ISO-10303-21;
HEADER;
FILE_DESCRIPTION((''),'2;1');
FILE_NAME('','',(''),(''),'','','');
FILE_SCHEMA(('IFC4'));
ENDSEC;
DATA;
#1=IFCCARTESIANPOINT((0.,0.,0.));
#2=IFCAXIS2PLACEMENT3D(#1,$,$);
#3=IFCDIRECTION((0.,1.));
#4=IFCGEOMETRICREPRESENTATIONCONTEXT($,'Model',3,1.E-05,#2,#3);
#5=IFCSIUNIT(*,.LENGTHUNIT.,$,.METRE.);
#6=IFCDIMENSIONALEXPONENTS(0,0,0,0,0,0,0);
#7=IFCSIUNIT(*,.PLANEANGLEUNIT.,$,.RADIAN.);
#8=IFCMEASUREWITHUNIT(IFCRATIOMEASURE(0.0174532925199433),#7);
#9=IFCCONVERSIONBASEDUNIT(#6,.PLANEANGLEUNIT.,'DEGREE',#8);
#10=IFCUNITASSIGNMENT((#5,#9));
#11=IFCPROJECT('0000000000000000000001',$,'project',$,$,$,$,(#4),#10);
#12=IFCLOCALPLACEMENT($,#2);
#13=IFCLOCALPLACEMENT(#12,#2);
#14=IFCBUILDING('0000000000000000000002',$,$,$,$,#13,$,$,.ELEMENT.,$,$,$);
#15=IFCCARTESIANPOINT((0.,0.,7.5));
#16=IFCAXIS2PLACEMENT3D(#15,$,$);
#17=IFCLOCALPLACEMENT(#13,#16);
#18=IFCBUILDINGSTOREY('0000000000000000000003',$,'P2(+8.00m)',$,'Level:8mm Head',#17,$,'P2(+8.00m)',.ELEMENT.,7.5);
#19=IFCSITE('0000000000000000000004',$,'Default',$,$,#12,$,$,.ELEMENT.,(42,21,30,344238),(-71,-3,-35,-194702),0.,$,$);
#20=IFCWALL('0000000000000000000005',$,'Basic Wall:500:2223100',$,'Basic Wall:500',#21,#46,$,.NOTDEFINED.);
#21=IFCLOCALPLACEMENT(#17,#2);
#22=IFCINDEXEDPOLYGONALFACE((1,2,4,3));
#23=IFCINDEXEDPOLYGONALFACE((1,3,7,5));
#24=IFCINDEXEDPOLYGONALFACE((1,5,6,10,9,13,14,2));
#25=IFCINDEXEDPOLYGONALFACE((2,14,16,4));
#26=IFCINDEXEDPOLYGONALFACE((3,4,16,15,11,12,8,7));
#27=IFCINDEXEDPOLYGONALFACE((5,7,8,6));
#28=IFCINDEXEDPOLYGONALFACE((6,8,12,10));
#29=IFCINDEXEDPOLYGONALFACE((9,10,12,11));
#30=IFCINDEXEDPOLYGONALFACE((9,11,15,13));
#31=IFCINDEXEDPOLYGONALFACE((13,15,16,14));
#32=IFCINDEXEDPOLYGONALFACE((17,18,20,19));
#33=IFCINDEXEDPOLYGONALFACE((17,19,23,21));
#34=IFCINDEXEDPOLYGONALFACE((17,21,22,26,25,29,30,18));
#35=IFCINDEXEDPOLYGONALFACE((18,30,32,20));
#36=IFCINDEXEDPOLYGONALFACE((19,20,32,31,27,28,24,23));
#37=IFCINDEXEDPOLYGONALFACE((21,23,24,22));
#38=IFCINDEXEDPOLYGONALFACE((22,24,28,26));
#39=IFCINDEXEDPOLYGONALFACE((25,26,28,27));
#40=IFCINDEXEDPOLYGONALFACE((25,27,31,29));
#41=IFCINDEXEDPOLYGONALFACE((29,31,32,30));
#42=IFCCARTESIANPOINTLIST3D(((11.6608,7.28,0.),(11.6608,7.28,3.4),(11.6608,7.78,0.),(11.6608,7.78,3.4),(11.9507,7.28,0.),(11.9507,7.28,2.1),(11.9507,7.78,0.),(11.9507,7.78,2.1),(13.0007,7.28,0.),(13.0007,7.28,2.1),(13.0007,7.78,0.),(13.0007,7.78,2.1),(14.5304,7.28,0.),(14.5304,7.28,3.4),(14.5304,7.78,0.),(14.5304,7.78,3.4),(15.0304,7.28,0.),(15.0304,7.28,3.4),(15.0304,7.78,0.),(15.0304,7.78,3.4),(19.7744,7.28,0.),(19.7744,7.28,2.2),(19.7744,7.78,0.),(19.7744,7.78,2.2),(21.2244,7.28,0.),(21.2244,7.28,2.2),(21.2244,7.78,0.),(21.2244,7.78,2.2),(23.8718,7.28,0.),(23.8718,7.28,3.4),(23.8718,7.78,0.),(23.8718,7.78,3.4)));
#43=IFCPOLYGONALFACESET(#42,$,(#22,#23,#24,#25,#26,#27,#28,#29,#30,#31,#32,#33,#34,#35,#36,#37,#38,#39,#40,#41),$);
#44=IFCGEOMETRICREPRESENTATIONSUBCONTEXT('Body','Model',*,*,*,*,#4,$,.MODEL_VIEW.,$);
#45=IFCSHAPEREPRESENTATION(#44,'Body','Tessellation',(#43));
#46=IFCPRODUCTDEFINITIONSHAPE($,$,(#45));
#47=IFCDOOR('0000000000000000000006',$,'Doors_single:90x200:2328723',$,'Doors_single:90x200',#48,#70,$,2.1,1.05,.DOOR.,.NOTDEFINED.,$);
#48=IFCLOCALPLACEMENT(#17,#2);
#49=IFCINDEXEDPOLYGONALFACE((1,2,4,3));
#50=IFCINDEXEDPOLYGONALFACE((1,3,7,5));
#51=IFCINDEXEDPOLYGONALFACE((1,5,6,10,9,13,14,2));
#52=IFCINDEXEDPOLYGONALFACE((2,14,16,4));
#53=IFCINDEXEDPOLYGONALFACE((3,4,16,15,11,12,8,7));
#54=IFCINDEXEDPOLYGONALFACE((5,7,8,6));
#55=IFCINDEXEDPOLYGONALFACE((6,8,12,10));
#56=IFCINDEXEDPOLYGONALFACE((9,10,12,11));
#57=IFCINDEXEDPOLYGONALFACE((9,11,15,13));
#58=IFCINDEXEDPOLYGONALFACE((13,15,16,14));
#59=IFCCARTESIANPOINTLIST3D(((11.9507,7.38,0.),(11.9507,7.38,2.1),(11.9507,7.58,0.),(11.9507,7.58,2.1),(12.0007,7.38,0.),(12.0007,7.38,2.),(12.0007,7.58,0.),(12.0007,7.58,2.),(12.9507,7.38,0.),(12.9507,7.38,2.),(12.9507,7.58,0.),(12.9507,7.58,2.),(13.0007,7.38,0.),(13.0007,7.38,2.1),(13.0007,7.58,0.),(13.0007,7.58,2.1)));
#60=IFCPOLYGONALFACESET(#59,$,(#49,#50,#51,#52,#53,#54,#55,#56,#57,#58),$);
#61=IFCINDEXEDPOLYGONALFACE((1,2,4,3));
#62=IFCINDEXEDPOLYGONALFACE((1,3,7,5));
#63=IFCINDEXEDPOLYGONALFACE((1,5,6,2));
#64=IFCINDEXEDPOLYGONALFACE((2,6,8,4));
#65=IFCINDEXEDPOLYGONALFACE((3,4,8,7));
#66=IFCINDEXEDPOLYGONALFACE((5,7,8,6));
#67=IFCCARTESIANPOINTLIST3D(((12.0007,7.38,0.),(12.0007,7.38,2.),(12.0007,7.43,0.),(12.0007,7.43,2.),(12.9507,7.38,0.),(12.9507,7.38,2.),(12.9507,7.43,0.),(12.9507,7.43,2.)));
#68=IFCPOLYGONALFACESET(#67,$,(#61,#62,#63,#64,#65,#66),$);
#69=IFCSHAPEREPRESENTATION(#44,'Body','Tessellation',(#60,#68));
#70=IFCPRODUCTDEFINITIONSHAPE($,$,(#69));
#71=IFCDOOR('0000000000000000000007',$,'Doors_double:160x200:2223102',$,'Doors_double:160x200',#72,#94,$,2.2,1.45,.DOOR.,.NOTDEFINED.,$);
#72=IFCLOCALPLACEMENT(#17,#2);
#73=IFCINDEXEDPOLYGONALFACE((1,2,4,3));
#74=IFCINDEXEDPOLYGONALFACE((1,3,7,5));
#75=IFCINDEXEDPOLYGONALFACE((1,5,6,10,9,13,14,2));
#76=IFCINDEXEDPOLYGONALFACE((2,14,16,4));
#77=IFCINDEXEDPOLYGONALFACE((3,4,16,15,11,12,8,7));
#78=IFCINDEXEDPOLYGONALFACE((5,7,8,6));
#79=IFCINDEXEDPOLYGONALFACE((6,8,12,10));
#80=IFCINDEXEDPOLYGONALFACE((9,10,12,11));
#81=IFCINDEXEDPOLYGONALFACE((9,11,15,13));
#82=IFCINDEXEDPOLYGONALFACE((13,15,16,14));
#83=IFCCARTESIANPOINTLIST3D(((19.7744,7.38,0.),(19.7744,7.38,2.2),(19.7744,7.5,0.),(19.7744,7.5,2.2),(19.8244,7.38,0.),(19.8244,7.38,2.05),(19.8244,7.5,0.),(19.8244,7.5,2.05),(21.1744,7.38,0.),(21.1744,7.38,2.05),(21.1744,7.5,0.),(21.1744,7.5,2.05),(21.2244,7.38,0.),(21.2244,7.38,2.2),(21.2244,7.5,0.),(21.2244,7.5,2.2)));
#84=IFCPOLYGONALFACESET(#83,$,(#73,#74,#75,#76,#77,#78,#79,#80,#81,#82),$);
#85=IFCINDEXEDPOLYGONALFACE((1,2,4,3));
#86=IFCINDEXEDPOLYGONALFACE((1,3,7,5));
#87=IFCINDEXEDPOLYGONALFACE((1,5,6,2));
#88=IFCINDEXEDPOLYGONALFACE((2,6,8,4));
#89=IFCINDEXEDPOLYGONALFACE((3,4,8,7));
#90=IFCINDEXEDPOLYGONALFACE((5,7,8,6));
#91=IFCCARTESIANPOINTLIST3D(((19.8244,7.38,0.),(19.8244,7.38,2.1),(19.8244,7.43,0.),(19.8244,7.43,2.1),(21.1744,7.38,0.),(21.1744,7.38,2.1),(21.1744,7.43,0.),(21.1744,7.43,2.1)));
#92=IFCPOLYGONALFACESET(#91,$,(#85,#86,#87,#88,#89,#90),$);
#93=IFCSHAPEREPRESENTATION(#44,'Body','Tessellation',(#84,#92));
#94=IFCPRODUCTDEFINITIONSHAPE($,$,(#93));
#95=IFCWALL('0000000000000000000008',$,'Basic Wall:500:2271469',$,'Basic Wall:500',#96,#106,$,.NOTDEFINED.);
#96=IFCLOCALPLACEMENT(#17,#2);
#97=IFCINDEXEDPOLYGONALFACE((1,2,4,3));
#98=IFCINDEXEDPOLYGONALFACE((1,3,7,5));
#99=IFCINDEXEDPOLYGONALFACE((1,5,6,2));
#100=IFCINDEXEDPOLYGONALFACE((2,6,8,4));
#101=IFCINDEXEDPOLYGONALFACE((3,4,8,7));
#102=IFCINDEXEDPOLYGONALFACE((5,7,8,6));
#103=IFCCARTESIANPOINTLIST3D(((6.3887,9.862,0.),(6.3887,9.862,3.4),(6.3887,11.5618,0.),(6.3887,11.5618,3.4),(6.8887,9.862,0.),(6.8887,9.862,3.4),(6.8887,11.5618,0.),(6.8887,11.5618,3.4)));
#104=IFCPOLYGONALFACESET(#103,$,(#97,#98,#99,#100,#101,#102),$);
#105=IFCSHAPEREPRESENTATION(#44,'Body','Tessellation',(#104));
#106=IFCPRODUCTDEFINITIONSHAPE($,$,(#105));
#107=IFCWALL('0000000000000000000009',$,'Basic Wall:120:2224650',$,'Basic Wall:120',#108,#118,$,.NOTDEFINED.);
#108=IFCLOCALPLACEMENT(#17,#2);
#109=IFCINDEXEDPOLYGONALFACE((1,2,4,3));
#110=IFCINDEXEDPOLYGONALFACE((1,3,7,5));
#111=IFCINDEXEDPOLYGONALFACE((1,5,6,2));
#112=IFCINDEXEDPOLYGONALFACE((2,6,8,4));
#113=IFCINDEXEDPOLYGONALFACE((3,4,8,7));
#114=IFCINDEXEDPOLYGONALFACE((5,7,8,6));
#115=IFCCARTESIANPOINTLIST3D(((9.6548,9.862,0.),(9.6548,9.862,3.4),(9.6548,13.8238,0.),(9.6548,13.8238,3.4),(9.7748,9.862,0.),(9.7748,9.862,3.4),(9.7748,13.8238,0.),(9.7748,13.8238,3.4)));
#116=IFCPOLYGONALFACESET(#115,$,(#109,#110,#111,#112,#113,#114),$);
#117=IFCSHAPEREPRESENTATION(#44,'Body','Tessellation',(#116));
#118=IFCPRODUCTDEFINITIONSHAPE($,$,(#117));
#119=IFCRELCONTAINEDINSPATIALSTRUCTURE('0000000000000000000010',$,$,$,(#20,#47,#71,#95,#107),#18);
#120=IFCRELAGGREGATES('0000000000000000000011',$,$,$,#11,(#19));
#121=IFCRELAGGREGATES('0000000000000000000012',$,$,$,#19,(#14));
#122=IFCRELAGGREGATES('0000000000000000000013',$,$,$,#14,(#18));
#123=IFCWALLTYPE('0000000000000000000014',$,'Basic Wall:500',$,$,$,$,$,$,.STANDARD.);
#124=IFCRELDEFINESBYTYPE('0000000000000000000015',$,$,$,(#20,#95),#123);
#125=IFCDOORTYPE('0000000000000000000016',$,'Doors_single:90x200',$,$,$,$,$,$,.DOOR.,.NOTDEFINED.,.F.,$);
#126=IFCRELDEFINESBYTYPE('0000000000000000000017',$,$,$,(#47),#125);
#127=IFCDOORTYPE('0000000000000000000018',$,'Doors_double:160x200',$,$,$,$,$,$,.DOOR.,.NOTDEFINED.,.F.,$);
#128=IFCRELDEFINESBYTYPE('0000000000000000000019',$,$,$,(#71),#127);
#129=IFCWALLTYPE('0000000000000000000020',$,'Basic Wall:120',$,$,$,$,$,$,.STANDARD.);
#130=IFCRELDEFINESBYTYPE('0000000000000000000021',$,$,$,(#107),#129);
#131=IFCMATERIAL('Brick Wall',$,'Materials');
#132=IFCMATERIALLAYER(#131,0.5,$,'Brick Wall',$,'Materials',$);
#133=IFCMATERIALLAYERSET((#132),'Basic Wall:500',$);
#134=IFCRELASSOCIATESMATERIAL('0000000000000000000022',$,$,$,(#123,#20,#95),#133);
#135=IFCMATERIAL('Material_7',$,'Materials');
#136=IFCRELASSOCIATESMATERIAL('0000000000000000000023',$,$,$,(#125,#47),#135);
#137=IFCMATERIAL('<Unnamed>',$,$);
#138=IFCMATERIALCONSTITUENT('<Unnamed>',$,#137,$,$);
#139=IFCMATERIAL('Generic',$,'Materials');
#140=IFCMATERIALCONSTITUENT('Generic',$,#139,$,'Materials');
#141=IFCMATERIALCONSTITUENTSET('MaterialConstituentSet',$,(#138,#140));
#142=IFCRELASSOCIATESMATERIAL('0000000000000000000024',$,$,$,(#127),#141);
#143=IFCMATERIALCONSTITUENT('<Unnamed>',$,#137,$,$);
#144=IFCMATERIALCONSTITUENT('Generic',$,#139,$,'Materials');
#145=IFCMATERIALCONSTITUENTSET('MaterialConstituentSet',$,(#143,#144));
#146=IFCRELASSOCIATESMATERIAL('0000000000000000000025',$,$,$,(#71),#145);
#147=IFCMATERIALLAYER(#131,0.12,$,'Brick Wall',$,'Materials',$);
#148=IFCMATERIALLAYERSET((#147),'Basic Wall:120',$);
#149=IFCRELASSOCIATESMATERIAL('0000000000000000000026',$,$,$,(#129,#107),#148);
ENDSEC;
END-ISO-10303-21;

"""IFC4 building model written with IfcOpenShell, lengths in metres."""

from ifc_helpers import new_model, entity, si_unit, converted_unit, direction, frame, frame_2d, origin, origin_2d_with_axis, place, context, subcontext, project, spatial, polyline, rectangle, outline, extrude, source, transform, mapped, material, layer, layer_set, layer_usage, constituent, constituent_set, type_object, type_shapes, element, fill, save


model = new_model("IFC4")

# Units and contexts
model_context = context("Model", 3, precision=1e-05, world=origin(), true_north=direction((0.0, 1.0)))
body_context = subcontext(model_context, "Body", "Model", "MODEL_VIEW")
ifc_project = project(units=[si_unit("LENGTHUNIT", "METRE"), converted_unit("PLANEANGLEUNIT", "DEGREE", entity("IfcRatioMeasure", 0.0174532925199433), si_unit("PLANEANGLEUNIT", "RADIAN"), dimensions=[0, 0, 0, 0, 0, 0, 0])], contexts=[model_context])

# Site, building, storey
site_placement = place(None, origin())
site = spatial("IfcSite", under=ifc_project, at=site_placement, Name="Default", CompositionType="ELEMENT", RefLatitude=(42, 21, 30, 344238), RefLongitude=(-71, -3, -35, -194702), RefElevation=0.0)
building_placement = place(site_placement, origin())
building = spatial("IfcBuilding", under=site, at=building_placement, CompositionType="ELEMENT")
storey_placement = place(building_placement, frame((0.0, 0.0, 7.5)))
storey = spatial("IfcBuildingStorey", under=building, at=storey_placement, Name="P2(+8.00m)", ObjectType="Level:8mm Head", LongName="P2(+8.00m)", CompositionType="ELEMENT", Elevation=7.5)

# Shared definitions
ifc_material_1 = material(Name="Brick Wall", Category="Materials")
ifc_material_2 = material(Name="<Unnamed>")
ifc_material_3 = material(Name="Generic", Category="Materials")

# Wall, openings, doors
ifc_layer_1 = layer(ifc_material_1, 0.5, Name="Brick Wall", Category="Materials")
ifc_layer_set_1 = layer_set([ifc_layer_1], Name="Basic Wall:500")
ifc_layer_usage_1 = layer_usage(ifc_layer_set_1, "AXIS2", "NEGATIVE", 0.25)
wall_type_1 = type_object("IfcWallType", Name="Basic Wall:500", PredefinedType="STANDARD", material=ifc_layer_set_1)
wall_1_placement = place(storey_placement, frame((11.6608, 7.53, 0.0)))
wall_1 = element("IfcWall", 1, at=wall_1_placement, inside=storey, type_object=wall_type_1, material=ifc_layer_usage_1, Name="Basic Wall:500:2223100", ObjectType="Basic Wall:500", PredefinedType="NOTDEFINED", context=body_context, shape_type="SweptSolid", body=[
    extrude(rectangle(XDim=12.211, YDim=0.5, at=frame_2d((6.1055, 0.0), x_axis=(-1.0, 0.0))), origin(), (0.0, 0.0, 1.0), 3.4),
])
opening_1_placement = place(storey_placement, frame((11.6608, 7.53, 0.0)))
element("IfcOpeningElement", 2, at=opening_1_placement, cuts=wall_1, PredefinedType="OPENING", context=body_context, shape_type="SweptSolid", body=[
    extrude(rectangle(XDim=3.4, YDim=0.5, at=frame_2d((0.0, 0.0), x_axis=(1.0, 0.0))), frame((2.8696, 0.0, 1.7), z_axis=(1.0, 0.0, 0.0), x_axis=(0.0, 0.0, -1.0)), (0.0, 0.0, 1.0), 0.5),
])
opening_2_placement = place(wall_1_placement, frame((1.3398, 0.25, 0.0)))
opening_2 = element("IfcOpeningElement", 3, at=opening_2_placement, cuts=wall_1, PredefinedType="OPENING", context=body_context, shape_type="SweptSolid", body=[
    extrude(rectangle(XDim=2.1, YDim=1.05, at=frame_2d((1.05, 0.525), x_axis=(1.0, 0.0))), frame((0.0, 0.0, 0.0), z_axis=(0.0, -1.0, 0.0), x_axis=(0.0, 0.0, 1.0)), (0.0, 0.0, 1.0), 0.5),
])
opening_3_placement = place(wall_1_placement, frame((9.5635, 0.25, 0.0)))
opening_3 = element("IfcOpeningElement", 4, at=opening_3_placement, cuts=wall_1, PredefinedType="OPENING", context=body_context, shape_type="SweptSolid", body=[
    extrude(rectangle(XDim=2.2, YDim=1.45, at=frame_2d((1.1, 0.725), x_axis=(-1.0, 0.0))), frame((0.0, 0.0, 0.0), z_axis=(0.0, -1.0, 0.0), x_axis=(0.0, 0.0, 1.0)), (0.0, 0.0, 1.0), 0.5),
])
ifc_material_4 = material(Name="Material_7", Category="Materials")
door_type_1 = type_object("IfcDoorType", Name="Doors_single:90x200", OperationType="NOTDEFINED", ParameterTakesPrecedence=False, PredefinedType="DOOR", material=ifc_material_4)
shared_shape_1 = source(origin(), body_context, "Body", "SweptSolid", [
    extrude(outline(polyline([(-0.525, -1.025), (-0.475, -1.025), (-0.475, 0.975), (0.475, 0.975), (0.475, -1.025), (0.525, -1.025), (0.525, 1.075), (-0.525, 1.075), (-0.525, -1.025)])), frame((0.525, 0.2, 1.025), z_axis=(0.0, 1.0, 0.0), x_axis=(-1.0, 0.0, 0.0)), (0.0, 0.0, 1.0), 0.2),
    extrude(rectangle(XDim=0.95, YDim=0.05, at=origin_2d_with_axis()), frame((0.525, 0.375, 0.0), z_axis=(0.0, 0.0, 1.0), x_axis=(-1.0, 0.0, 0.0)), (0.0, 0.0, 1.0), 2.0),
])
type_shapes(door_type_1, [shared_shape_1])
door_1_placement = place(opening_2_placement, frame((0.0, 0.0, 0.0), z_axis=(0.0, 0.0, 1.0), x_axis=(-1.0, 0.0, 0.0)))
door_1 = element("IfcDoor", 5, at=door_1_placement, inside=storey, type_object=door_type_1, material=ifc_material_4, Name="Doors_single:90x200:2328723", ObjectType="Doors_single:90x200", OperationType="NOTDEFINED", OverallHeight=2.1, OverallWidth=1.05, PredefinedType="DOOR", context=body_context, shape_type="MappedRepresentation", body=[
    mapped(shared_shape_1, transform((0.0, 0.0, 0.0), scale=1.0)),
])
fill(opening_2, door_1)
ifc_constituent_1 = constituent(ifc_material_2, Name="<Unnamed>")
ifc_constituent_2 = constituent(ifc_material_3, Name="Generic", Category="Materials")
ifc_constituent_set_1 = constituent_set(constituents=[ifc_constituent_1, ifc_constituent_2], Name="MaterialConstituentSet")
ifc_constituent_3 = constituent(ifc_material_2, Name="<Unnamed>")
ifc_constituent_4 = constituent(ifc_material_3, Name="Generic", Category="Materials")
ifc_constituent_set_2 = constituent_set(constituents=[ifc_constituent_3, ifc_constituent_4], Name="MaterialConstituentSet")
door_type_2 = type_object("IfcDoorType", Name="Doors_double:160x200", OperationType="NOTDEFINED", ParameterTakesPrecedence=False, PredefinedType="DOOR", material=ifc_constituent_set_2)
shared_shape_2 = source(origin(), body_context, "Body", "SweptSolid", [
    extrude(outline(polyline([(-0.725, -1.0625), (-0.675, -1.0625), (-0.675, 0.9875), (0.675, 0.9875), (0.675, -1.0625), (0.725, -1.0625), (0.725, 1.1375), (-0.725, 1.1375), (-0.725, -1.0625)])), frame((0.725, 0.28, 1.0625), z_axis=(0.0, 1.0, 0.0), x_axis=(-1.0, 0.0, 0.0)), (0.0, 0.0, 1.0), 0.12),
    extrude(rectangle(XDim=1.35, YDim=0.05, at=frame_2d((0.0, 0.0), x_axis=(1.0, 0.0))), frame((0.725, 0.375, 0.0), z_axis=(0.0, 0.0, 1.0), x_axis=(-1.0, 0.0, 0.0)), (0.0, 0.0, 1.0), 2.1),
])
type_shapes(door_type_2, [shared_shape_2])
door_2_placement = place(opening_3_placement, frame((0.0, 0.0, 0.0), z_axis=(0.0, 0.0, 1.0), x_axis=(-1.0, 0.0, 0.0)))
door_2 = element("IfcDoor", 6, at=door_2_placement, inside=storey, type_object=door_type_2, material=ifc_constituent_set_1, Name="Doors_double:160x200:2223102", ObjectType="Doors_double:160x200", OperationType="NOTDEFINED", OverallHeight=2.2, OverallWidth=1.45, PredefinedType="DOOR", context=body_context, shape_type="MappedRepresentation", body=[
    mapped(shared_shape_2, transform((0.0, 0.0, 0.0), scale=1.0)),
])
fill(opening_3, door_2)

# Walls
ifc_layer_usage_2 = layer_usage(ifc_layer_set_1, "AXIS2", "POSITIVE", -0.25)
wall_2_placement = place(storey_placement, frame((6.6387, 11.5618, 0.0), z_axis=(0.0, 0.0, 1.0), x_axis=(0.0, -1.0, 0.0)))
element("IfcWall", 7, at=wall_2_placement, inside=storey, type_object=wall_type_1, material=ifc_layer_usage_2, Name="Basic Wall:500:2271469", ObjectType="Basic Wall:500", PredefinedType="NOTDEFINED", context=body_context, shape_type="SweptSolid", body=[
    extrude(rectangle(XDim=1.6998, YDim=0.5, at=frame_2d((0.8499, 0.0), x_axis=(-1.0, 0.0))), origin(), (0.0, 0.0, 1.0), 3.4),
])
ifc_layer_2 = layer(ifc_material_1, 0.12, Name="Brick Wall", Category="Materials")
ifc_layer_set_2 = layer_set([ifc_layer_2], Name="Basic Wall:120")
ifc_layer_usage_3 = layer_usage(ifc_layer_set_2, "AXIS2", "POSITIVE", -0.06)
wall_type_2 = type_object("IfcWallType", Name="Basic Wall:120", PredefinedType="STANDARD", material=ifc_layer_set_2)
wall_3_placement = place(storey_placement, frame((9.7148, 9.862, 0.0), z_axis=(0.0, 0.0, 1.0), x_axis=(0.0, 1.0, 0.0)))
element("IfcWall", 8, at=wall_3_placement, inside=storey, type_object=wall_type_2, material=ifc_layer_usage_3, Name="Basic Wall:120:2224650", ObjectType="Basic Wall:120", PredefinedType="NOTDEFINED", context=body_context, shape_type="SweptSolid", body=[
    extrude(rectangle(XDim=3.9619, YDim=0.12, at=frame_2d((1.9809, 0.0), x_axis=(-1.0, 0.0))), origin(), (0.0, 0.0, 1.0), 3.4),
])

save(model, "model.ifc")
